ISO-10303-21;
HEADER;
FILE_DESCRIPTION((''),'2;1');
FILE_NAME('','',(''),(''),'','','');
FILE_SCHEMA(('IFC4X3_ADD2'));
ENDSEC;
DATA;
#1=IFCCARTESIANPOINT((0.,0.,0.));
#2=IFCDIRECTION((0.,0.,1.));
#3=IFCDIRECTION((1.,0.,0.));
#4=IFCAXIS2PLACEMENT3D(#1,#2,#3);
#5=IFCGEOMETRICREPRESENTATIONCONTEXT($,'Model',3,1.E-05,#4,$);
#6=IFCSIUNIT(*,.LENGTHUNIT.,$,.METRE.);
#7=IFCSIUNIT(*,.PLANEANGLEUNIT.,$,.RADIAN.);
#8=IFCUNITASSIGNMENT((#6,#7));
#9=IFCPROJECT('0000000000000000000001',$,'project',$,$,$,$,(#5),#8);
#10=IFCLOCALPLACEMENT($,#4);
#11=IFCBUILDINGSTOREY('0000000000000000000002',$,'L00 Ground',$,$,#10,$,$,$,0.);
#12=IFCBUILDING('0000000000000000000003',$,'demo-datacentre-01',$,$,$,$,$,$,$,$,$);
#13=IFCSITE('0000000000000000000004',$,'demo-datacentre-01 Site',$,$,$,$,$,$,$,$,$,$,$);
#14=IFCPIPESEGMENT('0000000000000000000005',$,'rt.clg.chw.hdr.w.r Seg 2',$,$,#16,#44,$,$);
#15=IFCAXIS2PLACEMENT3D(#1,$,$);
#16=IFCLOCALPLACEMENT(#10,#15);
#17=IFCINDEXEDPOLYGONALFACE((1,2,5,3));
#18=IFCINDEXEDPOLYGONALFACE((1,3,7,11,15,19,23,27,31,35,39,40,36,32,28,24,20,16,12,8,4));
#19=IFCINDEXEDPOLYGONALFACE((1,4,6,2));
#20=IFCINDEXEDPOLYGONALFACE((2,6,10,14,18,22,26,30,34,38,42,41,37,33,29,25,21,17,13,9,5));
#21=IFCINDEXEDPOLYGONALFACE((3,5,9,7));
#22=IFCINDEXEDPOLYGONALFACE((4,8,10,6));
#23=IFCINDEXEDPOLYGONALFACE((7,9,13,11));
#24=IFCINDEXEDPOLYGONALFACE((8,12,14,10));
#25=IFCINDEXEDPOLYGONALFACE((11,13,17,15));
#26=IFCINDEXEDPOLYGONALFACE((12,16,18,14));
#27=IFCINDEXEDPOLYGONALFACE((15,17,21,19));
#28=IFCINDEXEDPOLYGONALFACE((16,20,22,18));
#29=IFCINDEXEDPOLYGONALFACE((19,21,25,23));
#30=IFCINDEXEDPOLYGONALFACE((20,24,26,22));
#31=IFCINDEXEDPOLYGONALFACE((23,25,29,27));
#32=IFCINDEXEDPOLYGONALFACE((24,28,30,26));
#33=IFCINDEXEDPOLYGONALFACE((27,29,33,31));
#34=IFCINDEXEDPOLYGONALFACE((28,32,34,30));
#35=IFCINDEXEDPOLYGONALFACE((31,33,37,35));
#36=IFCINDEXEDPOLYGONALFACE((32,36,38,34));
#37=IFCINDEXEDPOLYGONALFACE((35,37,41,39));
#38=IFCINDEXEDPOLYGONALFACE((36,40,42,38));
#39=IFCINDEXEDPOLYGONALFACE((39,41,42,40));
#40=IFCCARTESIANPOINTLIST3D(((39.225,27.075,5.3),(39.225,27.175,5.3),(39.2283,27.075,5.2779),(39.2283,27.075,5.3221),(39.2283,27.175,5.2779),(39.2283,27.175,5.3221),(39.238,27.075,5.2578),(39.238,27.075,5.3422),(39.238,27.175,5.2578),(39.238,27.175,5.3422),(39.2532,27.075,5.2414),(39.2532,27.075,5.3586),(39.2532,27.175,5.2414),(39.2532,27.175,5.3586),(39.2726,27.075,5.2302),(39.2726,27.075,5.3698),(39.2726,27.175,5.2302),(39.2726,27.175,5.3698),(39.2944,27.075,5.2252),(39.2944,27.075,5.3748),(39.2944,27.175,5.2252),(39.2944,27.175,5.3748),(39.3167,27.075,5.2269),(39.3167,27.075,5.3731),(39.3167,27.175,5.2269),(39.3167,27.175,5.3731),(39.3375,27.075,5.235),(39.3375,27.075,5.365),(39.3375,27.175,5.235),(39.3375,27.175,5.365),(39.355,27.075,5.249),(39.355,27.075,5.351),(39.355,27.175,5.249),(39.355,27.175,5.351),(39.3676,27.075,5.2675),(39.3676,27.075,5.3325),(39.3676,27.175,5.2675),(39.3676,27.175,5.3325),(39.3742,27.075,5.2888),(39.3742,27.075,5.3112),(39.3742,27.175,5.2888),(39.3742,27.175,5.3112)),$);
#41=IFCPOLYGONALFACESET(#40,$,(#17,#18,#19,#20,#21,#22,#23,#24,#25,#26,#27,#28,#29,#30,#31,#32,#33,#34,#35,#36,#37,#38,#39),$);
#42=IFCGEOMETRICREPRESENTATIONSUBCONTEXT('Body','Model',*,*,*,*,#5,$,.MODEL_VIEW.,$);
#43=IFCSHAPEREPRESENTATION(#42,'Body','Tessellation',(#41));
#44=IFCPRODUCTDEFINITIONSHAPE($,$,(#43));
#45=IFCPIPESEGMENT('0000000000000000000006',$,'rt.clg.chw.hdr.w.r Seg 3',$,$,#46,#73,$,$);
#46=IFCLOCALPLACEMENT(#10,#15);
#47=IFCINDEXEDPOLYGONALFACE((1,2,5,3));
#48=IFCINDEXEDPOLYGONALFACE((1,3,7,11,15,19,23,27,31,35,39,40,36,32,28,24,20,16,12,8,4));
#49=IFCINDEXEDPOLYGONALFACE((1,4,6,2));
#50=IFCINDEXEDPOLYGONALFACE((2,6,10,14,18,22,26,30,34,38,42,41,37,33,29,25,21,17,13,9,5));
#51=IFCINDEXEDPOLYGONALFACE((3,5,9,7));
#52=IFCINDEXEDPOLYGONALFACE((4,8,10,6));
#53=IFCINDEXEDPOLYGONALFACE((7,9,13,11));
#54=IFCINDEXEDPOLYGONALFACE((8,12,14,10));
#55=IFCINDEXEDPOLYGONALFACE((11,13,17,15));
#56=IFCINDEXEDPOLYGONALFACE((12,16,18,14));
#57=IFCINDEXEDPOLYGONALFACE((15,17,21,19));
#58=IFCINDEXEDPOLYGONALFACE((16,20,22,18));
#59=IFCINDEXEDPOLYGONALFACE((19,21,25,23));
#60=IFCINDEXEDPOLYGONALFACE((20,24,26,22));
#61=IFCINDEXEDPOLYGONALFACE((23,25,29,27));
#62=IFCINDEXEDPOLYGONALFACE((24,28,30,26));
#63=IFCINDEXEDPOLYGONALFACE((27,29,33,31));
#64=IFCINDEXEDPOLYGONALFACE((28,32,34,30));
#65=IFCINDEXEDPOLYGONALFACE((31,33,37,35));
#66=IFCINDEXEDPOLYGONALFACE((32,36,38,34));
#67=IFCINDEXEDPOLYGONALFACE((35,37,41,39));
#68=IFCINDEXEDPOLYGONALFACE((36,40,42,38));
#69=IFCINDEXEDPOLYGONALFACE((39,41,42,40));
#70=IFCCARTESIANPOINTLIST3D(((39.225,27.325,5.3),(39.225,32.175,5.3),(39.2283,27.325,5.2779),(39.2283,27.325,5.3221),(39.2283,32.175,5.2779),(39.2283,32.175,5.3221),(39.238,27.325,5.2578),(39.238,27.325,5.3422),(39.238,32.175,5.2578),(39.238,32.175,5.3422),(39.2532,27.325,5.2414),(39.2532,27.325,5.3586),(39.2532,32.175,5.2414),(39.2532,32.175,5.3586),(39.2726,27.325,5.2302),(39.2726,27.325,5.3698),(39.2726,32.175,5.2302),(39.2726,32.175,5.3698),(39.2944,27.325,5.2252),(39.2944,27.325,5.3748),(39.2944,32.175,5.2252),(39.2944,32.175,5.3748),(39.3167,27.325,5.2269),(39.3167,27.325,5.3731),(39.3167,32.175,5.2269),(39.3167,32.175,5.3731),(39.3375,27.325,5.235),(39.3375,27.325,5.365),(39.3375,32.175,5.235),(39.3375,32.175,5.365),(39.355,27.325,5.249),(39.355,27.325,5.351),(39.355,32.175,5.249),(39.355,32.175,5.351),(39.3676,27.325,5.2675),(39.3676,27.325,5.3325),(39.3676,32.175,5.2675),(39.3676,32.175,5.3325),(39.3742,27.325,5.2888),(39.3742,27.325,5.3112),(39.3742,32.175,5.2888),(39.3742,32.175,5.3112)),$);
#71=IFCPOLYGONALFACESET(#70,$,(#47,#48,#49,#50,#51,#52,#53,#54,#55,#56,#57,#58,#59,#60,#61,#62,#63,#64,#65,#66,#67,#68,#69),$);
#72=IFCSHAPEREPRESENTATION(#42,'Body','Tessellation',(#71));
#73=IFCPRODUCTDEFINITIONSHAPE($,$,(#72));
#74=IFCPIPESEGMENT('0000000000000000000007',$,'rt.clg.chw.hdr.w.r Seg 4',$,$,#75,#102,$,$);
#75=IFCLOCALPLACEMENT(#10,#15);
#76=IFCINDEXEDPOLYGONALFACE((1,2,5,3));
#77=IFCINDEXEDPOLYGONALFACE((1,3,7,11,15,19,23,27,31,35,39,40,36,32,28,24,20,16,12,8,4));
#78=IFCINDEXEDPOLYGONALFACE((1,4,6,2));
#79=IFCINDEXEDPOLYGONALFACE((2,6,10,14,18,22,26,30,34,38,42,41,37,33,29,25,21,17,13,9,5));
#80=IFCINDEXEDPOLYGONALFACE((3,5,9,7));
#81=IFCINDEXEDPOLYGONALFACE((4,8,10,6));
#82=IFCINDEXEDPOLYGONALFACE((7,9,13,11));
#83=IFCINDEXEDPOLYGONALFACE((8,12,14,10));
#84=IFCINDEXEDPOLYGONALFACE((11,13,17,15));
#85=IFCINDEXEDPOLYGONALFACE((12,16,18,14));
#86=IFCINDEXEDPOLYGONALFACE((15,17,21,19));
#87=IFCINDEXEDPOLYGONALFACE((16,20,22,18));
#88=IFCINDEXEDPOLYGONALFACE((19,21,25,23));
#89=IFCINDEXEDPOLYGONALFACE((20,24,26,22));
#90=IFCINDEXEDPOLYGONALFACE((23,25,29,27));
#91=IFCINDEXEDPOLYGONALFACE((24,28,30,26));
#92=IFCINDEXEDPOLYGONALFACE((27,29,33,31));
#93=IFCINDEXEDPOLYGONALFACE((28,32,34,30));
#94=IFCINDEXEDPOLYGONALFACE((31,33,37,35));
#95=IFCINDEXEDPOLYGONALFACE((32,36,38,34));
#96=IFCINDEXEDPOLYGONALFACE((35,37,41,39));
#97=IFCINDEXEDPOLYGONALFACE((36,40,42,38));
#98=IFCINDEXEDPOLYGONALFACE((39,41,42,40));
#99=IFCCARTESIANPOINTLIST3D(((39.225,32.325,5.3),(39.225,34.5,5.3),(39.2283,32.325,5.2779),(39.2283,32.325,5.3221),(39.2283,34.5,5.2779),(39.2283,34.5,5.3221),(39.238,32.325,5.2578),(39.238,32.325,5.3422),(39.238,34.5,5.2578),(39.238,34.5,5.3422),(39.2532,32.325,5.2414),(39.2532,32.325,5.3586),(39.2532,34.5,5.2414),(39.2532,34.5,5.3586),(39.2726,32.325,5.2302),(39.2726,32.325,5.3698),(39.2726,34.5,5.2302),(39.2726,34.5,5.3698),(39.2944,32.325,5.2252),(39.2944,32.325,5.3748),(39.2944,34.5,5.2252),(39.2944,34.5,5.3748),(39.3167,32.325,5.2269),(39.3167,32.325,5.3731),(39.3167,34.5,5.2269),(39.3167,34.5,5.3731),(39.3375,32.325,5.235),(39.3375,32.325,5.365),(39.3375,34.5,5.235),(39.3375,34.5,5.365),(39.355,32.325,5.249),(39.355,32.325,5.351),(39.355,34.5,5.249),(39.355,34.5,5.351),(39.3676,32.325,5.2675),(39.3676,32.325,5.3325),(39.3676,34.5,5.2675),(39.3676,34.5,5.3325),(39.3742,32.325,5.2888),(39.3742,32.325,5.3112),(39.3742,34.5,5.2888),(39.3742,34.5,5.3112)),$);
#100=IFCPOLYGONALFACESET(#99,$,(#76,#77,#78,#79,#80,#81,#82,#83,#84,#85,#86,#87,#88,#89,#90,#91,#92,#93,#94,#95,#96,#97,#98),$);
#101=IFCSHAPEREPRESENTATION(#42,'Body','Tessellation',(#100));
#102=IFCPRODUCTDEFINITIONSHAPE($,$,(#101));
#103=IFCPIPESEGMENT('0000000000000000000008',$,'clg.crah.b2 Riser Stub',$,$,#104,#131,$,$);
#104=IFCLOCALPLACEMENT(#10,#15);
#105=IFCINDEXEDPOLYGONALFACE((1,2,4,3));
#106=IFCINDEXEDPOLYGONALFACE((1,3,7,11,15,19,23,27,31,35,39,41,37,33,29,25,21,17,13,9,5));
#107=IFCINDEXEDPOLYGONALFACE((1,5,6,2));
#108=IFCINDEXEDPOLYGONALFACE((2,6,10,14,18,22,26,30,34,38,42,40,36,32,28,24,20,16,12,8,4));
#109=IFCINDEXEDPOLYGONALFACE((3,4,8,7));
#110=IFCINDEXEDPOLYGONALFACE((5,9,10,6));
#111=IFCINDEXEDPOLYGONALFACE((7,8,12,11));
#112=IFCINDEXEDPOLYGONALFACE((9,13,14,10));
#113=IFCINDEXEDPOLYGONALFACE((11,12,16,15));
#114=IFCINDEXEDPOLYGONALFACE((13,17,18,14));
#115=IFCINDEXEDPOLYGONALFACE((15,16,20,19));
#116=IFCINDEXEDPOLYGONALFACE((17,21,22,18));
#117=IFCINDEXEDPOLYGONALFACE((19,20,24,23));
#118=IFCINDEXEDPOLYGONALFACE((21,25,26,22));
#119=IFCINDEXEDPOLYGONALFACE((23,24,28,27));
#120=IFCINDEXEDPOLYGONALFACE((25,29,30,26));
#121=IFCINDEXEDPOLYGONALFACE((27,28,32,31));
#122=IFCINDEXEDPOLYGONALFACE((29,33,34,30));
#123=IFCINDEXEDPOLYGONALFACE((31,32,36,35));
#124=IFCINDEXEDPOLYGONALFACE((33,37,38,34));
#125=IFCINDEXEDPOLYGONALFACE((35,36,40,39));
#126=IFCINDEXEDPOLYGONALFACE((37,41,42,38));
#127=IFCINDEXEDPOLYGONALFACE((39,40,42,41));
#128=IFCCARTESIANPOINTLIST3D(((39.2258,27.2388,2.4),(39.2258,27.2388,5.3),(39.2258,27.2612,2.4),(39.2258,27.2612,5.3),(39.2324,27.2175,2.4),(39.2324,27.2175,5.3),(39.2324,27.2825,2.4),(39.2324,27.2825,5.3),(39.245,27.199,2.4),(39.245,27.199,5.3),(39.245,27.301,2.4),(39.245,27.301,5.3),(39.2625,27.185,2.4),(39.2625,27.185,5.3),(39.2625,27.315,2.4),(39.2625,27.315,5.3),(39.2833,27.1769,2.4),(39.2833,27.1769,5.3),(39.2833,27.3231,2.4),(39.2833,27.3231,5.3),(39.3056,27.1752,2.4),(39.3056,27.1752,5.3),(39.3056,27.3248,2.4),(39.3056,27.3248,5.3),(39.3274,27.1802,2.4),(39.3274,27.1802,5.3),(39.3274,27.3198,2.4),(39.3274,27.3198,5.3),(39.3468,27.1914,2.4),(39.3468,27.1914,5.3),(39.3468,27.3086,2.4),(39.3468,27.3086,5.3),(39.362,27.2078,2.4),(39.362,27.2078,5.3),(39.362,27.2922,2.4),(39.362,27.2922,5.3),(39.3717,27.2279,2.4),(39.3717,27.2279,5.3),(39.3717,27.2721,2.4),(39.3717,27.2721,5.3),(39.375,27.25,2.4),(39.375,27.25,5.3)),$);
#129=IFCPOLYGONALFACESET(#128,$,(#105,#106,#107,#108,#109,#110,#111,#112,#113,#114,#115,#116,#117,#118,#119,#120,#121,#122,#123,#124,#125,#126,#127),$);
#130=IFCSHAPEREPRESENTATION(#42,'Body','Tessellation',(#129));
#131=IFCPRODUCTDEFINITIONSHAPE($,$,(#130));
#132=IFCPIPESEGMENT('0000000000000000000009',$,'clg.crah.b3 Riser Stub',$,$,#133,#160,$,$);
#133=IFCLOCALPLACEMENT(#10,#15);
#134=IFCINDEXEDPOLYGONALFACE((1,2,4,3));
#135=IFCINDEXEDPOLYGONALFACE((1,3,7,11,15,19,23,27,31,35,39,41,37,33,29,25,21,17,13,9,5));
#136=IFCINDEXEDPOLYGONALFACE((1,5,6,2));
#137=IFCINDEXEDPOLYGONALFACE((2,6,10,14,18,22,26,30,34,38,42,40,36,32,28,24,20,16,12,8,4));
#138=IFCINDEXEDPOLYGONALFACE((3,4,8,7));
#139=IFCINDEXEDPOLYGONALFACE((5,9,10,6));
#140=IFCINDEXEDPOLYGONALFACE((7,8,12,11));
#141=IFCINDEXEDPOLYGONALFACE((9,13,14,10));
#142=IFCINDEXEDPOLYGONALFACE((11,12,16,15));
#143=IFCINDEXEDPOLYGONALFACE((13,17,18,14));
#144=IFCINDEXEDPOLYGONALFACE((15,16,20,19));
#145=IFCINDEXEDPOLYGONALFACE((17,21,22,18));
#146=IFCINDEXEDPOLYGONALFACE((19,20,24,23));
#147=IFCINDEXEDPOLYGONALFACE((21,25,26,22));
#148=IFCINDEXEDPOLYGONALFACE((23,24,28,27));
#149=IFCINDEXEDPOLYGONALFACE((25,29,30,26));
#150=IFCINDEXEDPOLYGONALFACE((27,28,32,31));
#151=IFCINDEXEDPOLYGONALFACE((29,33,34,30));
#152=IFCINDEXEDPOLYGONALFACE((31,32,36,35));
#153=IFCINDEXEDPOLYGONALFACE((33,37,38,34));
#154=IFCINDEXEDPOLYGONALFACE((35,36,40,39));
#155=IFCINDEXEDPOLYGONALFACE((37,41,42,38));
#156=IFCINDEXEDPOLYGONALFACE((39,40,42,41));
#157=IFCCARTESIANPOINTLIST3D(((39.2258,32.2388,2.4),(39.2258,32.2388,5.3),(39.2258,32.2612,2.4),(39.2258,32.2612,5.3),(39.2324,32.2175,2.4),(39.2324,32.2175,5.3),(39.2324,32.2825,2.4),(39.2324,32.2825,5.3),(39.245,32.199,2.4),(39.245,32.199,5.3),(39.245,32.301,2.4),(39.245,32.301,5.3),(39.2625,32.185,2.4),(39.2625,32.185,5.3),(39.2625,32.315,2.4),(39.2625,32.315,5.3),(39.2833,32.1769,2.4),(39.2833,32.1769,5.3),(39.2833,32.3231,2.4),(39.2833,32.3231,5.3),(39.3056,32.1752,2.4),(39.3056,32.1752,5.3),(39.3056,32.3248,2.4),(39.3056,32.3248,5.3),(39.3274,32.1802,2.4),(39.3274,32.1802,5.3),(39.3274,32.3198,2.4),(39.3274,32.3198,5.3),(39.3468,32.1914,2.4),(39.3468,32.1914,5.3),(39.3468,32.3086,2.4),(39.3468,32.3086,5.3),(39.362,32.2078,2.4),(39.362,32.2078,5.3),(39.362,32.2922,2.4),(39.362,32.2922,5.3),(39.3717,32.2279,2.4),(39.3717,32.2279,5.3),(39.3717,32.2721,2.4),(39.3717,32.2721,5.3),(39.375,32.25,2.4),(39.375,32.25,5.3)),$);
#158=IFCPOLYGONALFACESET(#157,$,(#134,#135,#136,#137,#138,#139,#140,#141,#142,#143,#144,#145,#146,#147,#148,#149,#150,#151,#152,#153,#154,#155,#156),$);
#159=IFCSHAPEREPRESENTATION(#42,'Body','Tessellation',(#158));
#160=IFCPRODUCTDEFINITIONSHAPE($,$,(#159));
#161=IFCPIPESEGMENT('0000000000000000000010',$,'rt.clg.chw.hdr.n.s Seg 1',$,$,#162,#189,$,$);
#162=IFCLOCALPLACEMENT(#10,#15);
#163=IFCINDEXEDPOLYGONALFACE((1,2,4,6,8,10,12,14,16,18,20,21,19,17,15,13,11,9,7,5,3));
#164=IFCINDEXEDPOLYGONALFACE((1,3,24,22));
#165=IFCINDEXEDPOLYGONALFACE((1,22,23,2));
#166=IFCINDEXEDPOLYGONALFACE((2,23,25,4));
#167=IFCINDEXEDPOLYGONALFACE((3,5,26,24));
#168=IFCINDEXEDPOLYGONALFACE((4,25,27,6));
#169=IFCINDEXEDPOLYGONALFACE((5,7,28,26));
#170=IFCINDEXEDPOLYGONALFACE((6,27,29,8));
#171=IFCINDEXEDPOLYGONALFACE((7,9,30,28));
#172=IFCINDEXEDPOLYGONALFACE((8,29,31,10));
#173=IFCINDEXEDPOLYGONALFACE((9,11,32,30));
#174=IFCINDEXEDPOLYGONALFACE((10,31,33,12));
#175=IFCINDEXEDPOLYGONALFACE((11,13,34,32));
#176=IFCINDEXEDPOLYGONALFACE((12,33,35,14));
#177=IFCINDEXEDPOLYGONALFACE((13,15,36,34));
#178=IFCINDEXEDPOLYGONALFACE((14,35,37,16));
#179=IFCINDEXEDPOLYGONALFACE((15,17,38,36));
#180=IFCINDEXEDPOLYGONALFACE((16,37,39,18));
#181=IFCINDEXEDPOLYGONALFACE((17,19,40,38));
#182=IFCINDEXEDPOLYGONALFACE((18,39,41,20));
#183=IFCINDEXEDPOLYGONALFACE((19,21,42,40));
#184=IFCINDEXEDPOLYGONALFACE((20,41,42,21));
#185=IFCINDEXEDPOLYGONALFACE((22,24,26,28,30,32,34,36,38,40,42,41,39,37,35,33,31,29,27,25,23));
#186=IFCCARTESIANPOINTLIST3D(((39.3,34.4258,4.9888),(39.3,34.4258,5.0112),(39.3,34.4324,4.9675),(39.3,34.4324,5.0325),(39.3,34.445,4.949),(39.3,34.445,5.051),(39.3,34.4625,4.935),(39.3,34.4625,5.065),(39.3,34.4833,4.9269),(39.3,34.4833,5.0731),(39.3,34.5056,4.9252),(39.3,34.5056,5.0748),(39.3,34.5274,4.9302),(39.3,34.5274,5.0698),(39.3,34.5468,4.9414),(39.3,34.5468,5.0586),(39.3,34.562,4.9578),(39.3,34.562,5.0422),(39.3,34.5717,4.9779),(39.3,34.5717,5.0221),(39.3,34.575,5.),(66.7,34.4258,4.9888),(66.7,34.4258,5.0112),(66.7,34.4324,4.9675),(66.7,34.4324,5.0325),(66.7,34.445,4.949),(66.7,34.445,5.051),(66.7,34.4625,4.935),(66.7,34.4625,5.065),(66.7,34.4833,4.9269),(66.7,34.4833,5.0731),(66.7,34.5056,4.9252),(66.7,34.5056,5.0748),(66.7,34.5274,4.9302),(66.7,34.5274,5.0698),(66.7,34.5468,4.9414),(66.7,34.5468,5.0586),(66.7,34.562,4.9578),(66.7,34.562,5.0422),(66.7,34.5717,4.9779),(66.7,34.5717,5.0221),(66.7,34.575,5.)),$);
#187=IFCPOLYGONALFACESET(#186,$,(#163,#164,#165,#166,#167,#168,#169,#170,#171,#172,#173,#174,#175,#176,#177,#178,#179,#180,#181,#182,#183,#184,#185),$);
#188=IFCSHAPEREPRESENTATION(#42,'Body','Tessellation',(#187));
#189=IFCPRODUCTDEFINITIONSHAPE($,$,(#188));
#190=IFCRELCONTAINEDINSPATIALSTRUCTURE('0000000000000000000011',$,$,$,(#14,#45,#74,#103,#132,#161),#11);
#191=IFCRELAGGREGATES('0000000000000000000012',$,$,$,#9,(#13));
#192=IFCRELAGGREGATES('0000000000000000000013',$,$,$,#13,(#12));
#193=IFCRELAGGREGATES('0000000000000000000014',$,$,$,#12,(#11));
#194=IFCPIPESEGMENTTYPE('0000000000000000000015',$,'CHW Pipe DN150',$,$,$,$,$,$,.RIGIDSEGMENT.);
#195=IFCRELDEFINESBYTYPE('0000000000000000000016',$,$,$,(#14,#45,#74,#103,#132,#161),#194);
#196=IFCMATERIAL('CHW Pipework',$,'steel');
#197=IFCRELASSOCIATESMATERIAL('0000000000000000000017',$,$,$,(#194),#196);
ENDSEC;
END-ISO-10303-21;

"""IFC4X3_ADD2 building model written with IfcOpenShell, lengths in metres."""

from ifc_helpers import new_model, si_unit, frame, origin_with_axes, place, context, subcontext, project, spatial, circle, extrude, material, type_object, element, save


model = new_model("IFC4X3_ADD2")

# Units and contexts
model_context = context("Model", 3, precision=1e-05, world=origin_with_axes())
body_context = subcontext(model_context, "Body", "Model", "MODEL_VIEW")
ifc_project = project(units=[si_unit("LENGTHUNIT", "METRE"), si_unit("PLANEANGLEUNIT", "RADIAN")], contexts=[model_context])

# Site, building, storey
site = spatial("IfcSite", under=ifc_project, Name="demo-datacentre-01 Site")
building = spatial("IfcBuilding", under=site, Name="demo-datacentre-01")
storey_placement = place(None, origin_with_axes())
storey = spatial("IfcBuildingStorey", under=building, at=storey_placement, Name="L00 Ground", Elevation=0.0)

# Shared definitions
ifc_material = material(Name="CHW Pipework", Category="steel")

# Pipe segments
pipe_segment_type_1 = type_object("IfcPipeSegmentType", Name="CHW Pipe DN150", PredefinedType="RIGIDSEGMENT", material=ifc_material)
pipe_segment_1_placement = place(storey_placement, frame((39.3, 27.075, 5.3), z_axis=(0.0, 1.0, 0.0), x_axis=(-1.0, 0.0, 0.0)))
element("IfcPipeSegment", 1, at=pipe_segment_1_placement, inside=storey, type_object=pipe_segment_type_1, Name="rt.clg.chw.hdr.w.r Seg 2", context=body_context, shape_type="SweptSolid", body=[
    extrude(circle(Radius=0.075), origin_with_axes(), (0.0, 0.0, 1.0), 0.1),
])
pipe_segment_2_placement = place(storey_placement, frame((39.3, 27.325, 5.3), z_axis=(0.0, 1.0, 0.0), x_axis=(-1.0, 0.0, 0.0)))
element("IfcPipeSegment", 2, at=pipe_segment_2_placement, inside=storey, type_object=pipe_segment_type_1, Name="rt.clg.chw.hdr.w.r Seg 3", context=body_context, shape_type="SweptSolid", body=[
    extrude(circle(Radius=0.075), origin_with_axes(), (0.0, 0.0, 1.0), 4.85),
])
pipe_segment_3_placement = place(storey_placement, frame((39.3, 32.325, 5.3), z_axis=(0.0, 1.0, 0.0), x_axis=(-1.0, 0.0, 0.0)))
element("IfcPipeSegment", 3, at=pipe_segment_3_placement, inside=storey, type_object=pipe_segment_type_1, Name="rt.clg.chw.hdr.w.r Seg 4", context=body_context, shape_type="SweptSolid", body=[
    extrude(circle(Radius=0.075), origin_with_axes(), (0.0, 0.0, 1.0), 2.175),
])
for number, where, z_axis, x_axis, name in (
    (4, (39.3, 27.25, 5.3), (0.0, 0.0, -1.0), (1.0, 0.0, 0.0), "clg.crah.b2 Riser Stub"),
    (5, (39.3, 32.25, 5.3), (0.0, 0.0, -1.0), (1.0, 0.0, 0.0), "clg.crah.b3 Riser Stub"),
):
    element("IfcPipeSegment", number, at=place(storey_placement, frame(where, z_axis=z_axis, x_axis=x_axis)), inside=storey, type_object=pipe_segment_type_1, Name=name, context=body_context, shape_type="SweptSolid", body=[
        extrude(circle(Radius=0.075), origin_with_axes(), (0.0, 0.0, 1.0), 2.9),
    ])
pipe_segment_4_placement = place(storey_placement, frame((39.3, 34.5, 5.0), z_axis=(1.0, 0.0, 0.0), x_axis=(0.0, 1.0, 0.0)))
element("IfcPipeSegment", 6, at=pipe_segment_4_placement, inside=storey, type_object=pipe_segment_type_1, Name="rt.clg.chw.hdr.n.s Seg 1", context=body_context, shape_type="SweptSolid", body=[
    extrude(circle(Radius=0.075), origin_with_axes(), (0.0, 0.0, 1.0), 27.4),
])

save(model, "model.ifc")
